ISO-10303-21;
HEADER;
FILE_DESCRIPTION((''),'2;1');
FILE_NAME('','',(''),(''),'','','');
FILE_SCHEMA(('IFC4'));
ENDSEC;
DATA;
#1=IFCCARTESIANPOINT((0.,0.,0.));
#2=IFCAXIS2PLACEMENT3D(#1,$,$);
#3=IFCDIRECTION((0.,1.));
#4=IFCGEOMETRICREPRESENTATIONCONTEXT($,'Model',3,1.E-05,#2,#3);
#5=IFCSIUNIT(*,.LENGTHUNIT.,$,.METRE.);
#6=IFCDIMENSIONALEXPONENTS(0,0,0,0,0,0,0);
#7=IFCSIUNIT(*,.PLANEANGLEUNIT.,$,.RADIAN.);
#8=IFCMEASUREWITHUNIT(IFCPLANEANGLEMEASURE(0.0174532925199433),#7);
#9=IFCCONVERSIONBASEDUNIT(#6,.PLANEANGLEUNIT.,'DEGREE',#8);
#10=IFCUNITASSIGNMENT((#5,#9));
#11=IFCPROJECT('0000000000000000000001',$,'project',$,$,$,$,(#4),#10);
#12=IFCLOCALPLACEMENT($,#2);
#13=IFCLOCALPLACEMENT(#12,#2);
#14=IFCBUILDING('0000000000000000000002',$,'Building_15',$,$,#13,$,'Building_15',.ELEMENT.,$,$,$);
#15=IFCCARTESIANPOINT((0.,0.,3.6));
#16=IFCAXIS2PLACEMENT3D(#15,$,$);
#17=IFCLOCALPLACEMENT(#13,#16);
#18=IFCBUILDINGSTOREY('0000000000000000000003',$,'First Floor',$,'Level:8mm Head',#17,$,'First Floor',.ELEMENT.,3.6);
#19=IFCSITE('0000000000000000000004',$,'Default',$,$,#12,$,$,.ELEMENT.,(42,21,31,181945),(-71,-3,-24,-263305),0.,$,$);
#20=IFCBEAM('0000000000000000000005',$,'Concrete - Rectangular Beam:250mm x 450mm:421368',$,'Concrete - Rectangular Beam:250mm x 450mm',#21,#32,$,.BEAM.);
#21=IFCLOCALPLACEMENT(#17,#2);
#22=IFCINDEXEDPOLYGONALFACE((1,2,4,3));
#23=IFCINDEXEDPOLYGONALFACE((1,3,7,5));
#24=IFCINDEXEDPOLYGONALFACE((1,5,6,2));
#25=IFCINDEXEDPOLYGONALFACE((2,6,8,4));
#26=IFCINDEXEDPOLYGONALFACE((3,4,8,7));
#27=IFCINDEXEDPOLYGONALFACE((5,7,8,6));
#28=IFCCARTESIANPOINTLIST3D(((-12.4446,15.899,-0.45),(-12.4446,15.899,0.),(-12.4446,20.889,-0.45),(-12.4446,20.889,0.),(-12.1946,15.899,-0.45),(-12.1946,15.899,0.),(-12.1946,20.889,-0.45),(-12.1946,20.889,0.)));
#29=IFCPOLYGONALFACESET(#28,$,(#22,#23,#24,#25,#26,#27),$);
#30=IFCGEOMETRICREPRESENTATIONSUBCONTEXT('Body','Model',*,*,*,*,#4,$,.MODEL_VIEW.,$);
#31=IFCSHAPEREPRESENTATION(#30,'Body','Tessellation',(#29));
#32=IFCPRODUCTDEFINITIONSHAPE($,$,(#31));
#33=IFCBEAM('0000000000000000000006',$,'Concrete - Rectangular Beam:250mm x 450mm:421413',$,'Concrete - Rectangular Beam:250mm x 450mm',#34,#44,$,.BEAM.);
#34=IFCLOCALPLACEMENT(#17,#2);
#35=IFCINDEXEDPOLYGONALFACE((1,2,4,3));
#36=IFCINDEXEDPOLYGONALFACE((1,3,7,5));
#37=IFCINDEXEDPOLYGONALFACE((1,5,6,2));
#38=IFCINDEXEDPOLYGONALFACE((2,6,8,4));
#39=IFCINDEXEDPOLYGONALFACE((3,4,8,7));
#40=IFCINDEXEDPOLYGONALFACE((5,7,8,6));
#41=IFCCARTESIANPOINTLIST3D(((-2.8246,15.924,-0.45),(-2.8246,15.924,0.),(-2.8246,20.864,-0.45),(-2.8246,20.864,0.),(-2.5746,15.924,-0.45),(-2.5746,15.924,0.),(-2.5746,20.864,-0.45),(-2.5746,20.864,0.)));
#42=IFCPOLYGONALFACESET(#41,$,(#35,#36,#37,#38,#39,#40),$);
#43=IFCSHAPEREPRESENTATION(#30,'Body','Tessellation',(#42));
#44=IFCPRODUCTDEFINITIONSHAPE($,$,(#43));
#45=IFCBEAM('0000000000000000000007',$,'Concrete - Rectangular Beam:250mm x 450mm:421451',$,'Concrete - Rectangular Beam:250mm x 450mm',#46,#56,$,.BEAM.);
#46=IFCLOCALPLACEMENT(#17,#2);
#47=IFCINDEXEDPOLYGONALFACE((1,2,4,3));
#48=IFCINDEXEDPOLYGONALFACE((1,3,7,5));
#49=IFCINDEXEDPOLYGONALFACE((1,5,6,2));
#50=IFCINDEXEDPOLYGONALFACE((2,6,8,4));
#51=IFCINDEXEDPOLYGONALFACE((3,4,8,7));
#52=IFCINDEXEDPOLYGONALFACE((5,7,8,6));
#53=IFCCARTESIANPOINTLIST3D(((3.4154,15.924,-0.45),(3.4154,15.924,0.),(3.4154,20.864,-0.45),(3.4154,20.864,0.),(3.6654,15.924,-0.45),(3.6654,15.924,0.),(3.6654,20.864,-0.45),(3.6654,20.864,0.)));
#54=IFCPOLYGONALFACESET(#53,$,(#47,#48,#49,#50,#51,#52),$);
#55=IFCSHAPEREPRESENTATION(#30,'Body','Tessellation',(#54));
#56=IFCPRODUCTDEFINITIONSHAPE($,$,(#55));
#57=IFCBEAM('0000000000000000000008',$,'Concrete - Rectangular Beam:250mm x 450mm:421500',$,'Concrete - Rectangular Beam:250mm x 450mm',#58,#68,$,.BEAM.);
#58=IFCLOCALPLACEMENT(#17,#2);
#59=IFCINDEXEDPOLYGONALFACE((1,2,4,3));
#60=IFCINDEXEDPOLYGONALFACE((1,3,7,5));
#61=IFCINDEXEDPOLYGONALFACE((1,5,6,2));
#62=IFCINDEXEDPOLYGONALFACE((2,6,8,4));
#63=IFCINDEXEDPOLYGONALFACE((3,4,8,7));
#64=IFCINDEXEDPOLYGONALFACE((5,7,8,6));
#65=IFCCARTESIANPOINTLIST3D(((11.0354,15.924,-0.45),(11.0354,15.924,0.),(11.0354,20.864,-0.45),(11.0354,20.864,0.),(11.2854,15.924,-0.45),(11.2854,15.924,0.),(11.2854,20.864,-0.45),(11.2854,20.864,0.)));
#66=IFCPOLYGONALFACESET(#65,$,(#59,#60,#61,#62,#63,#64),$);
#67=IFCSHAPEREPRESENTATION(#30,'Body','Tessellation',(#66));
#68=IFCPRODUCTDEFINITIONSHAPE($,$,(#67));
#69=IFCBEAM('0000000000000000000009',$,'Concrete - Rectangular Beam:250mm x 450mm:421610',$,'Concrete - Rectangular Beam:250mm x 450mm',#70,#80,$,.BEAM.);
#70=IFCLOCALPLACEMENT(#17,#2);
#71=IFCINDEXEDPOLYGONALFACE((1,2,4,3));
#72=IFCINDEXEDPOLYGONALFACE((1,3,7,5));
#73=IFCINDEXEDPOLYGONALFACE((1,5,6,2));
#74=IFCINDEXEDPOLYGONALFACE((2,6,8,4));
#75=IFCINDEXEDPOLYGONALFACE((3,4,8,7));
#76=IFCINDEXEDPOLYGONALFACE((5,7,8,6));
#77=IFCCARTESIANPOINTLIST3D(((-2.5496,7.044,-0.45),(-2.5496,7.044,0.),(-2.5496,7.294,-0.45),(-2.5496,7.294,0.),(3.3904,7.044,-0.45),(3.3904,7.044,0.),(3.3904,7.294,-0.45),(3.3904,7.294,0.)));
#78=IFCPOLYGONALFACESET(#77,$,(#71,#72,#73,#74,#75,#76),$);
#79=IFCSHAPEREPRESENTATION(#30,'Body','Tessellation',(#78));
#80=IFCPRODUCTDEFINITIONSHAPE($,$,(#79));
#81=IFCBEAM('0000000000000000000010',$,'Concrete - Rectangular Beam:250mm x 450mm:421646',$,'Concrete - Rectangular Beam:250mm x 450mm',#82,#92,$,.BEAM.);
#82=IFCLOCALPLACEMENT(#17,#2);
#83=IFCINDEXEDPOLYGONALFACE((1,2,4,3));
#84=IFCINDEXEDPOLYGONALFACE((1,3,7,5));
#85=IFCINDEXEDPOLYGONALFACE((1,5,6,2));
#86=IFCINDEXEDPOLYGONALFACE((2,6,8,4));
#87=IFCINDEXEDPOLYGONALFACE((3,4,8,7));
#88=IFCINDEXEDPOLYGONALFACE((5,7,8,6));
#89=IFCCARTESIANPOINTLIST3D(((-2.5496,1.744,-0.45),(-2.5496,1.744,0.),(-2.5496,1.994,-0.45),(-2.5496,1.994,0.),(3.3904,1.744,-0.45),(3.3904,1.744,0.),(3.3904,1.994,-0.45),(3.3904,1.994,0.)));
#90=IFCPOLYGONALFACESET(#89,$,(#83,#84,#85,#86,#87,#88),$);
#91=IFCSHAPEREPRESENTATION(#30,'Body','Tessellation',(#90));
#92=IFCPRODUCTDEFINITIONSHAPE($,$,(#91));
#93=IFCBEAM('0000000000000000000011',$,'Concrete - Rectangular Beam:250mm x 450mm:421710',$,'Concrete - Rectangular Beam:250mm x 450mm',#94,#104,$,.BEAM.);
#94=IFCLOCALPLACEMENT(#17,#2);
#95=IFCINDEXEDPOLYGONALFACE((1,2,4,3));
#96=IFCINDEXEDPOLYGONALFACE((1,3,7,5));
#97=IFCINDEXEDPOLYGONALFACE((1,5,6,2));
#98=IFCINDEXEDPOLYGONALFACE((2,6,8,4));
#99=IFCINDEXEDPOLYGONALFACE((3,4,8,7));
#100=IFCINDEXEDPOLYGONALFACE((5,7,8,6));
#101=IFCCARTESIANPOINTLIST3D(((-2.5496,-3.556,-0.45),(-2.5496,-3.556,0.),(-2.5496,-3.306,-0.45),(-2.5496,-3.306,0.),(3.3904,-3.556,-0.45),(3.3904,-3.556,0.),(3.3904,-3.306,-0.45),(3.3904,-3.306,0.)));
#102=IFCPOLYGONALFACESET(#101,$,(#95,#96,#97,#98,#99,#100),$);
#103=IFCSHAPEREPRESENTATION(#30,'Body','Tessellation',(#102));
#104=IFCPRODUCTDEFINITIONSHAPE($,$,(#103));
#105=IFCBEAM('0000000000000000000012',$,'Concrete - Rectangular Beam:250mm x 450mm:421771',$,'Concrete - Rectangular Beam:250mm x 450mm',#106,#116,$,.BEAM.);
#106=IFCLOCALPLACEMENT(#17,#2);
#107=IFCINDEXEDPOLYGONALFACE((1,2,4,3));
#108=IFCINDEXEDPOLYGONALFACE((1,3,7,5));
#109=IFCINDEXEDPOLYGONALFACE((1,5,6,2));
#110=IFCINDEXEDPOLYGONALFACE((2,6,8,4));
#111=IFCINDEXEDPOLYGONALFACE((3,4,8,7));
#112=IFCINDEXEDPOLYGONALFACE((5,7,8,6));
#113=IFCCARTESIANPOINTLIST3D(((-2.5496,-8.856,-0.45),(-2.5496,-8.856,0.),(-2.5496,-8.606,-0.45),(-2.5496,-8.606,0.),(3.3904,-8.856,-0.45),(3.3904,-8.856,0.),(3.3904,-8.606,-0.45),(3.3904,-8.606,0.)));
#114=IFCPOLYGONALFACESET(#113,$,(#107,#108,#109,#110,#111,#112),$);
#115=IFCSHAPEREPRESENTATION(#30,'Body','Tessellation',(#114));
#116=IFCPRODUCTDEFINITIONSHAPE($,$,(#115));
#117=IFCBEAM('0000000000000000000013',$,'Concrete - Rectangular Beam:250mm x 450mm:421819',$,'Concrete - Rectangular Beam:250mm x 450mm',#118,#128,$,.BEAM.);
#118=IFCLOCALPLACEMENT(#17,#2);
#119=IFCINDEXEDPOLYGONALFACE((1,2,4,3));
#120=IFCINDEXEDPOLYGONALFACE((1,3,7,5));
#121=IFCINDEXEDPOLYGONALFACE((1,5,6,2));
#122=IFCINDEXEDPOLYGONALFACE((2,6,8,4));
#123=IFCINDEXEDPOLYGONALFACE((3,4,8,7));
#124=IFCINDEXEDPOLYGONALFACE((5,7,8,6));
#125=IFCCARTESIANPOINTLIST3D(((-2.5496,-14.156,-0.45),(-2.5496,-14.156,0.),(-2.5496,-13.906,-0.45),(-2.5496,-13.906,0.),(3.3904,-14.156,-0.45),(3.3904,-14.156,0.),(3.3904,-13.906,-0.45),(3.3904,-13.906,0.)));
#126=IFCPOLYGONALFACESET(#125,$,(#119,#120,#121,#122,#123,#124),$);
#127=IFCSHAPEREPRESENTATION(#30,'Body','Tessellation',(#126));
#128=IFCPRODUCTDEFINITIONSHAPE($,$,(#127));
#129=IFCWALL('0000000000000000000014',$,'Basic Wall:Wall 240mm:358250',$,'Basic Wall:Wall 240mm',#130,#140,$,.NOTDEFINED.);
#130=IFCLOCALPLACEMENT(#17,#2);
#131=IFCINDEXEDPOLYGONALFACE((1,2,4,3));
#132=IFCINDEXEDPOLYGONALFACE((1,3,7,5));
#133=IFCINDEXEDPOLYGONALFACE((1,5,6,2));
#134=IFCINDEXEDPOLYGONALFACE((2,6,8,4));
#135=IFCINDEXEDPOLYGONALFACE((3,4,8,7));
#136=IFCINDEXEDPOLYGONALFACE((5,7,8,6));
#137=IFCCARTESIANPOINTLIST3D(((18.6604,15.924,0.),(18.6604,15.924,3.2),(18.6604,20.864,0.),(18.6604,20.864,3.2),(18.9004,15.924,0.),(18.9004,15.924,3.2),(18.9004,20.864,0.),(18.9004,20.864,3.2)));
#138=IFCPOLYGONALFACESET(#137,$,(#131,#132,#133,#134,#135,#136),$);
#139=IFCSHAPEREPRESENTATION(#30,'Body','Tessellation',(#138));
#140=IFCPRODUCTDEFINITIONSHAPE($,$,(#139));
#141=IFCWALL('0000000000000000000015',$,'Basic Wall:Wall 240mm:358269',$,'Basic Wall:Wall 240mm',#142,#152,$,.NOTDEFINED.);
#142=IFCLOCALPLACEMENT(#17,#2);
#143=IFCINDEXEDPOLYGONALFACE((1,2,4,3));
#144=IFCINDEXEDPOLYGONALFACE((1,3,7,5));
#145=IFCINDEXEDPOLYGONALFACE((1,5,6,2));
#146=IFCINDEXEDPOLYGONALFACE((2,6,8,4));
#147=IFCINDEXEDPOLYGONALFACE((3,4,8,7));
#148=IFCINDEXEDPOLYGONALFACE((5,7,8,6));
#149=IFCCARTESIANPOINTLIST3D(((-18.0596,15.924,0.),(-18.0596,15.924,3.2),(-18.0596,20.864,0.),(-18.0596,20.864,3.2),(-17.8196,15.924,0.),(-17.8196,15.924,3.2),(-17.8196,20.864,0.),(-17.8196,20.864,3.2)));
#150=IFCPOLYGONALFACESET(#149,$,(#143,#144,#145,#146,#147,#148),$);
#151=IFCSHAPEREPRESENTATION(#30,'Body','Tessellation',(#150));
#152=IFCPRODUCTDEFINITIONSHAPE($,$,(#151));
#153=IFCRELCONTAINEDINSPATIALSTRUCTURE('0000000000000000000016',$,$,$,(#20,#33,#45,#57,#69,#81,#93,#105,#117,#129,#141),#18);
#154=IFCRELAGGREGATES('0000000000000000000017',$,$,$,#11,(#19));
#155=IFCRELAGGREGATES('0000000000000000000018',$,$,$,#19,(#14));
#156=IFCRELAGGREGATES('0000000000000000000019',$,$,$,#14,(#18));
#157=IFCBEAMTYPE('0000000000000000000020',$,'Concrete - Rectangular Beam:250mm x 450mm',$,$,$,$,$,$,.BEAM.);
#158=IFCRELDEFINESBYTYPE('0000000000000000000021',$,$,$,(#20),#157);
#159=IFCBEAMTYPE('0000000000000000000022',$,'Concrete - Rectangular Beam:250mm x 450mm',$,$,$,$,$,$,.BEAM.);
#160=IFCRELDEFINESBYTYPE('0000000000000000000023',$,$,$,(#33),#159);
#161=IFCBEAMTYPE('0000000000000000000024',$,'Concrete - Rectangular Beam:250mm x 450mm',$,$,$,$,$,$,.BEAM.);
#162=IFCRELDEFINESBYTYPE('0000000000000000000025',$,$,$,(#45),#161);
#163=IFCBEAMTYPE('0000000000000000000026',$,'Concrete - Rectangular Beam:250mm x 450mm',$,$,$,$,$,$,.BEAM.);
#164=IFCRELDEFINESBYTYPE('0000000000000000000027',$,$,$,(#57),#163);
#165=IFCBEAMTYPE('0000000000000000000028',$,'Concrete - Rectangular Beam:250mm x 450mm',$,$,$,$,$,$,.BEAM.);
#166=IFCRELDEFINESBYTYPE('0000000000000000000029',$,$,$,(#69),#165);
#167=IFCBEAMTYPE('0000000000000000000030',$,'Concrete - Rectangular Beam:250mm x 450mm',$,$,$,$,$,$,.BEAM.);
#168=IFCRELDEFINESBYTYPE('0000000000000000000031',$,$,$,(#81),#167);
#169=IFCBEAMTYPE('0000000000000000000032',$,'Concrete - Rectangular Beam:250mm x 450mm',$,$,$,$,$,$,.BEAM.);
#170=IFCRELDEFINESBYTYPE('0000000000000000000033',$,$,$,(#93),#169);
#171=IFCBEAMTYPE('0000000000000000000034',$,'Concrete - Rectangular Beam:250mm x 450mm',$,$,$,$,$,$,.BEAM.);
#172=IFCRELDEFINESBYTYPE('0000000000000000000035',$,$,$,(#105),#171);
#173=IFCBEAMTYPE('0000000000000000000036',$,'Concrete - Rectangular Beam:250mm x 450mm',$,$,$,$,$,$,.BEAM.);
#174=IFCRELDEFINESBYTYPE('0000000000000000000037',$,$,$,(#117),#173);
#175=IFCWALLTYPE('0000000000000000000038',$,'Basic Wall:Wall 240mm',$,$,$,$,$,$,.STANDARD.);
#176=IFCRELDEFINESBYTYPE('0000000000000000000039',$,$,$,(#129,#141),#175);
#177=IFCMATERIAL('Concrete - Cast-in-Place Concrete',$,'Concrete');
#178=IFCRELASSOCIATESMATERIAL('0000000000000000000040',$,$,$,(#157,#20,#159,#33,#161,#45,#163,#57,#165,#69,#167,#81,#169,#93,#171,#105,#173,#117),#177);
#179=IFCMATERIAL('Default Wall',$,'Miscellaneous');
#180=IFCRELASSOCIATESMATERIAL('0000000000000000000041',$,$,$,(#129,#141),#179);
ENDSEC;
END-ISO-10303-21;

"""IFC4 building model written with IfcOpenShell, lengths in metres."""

from ifc_helpers import new_model, entity, si_unit, converted_unit, direction, frame, origin, place, context, subcontext, project, spatial, indexed_curve, outline, extrude, source, transform, mapped, material, type_object, type_shapes, element, save


model = new_model("IFC4")

# Units and contexts
model_context = context("Model", 3, precision=1e-05, world=origin(), true_north=direction((0.0, 1.0)))
body_context = subcontext(model_context, "Body", "Model", "MODEL_VIEW")
ifc_project = project(units=[si_unit("LENGTHUNIT", "METRE"), converted_unit("PLANEANGLEUNIT", "DEGREE", entity("IfcPlaneAngleMeasure", 0.0174532925199433), si_unit("PLANEANGLEUNIT", "RADIAN"), dimensions=[0, 0, 0, 0, 0, 0, 0])], contexts=[model_context])

# Site, building, storey
site_placement = place(None, origin())
site = spatial("IfcSite", under=ifc_project, at=site_placement, Name="Default", CompositionType="ELEMENT", RefLatitude=(42, 21, 31, 181945), RefLongitude=(-71, -3, -24, -263305), RefElevation=0.0)
building_placement = place(site_placement, origin())
building = spatial("IfcBuilding", under=site, at=building_placement, Name="Building_15", LongName="Building_15", CompositionType="ELEMENT")
storey_placement = place(building_placement, frame((0.0, 0.0, 3.6)))
storey = spatial("IfcBuildingStorey", under=building, at=storey_placement, Name="First Floor", ObjectType="Level:8mm Head", LongName="First Floor", CompositionType="ELEMENT", Elevation=3.6)

# Beams
ifc_material_1 = material(Name="Concrete - Cast-in-Place Concrete", Category="Concrete")
beam_type_1 = type_object("IfcBeamType", Name="Concrete - Rectangular Beam:250mm x 450mm", PredefinedType="BEAM", material=ifc_material_1)
shared_shape_1 = source(origin(), body_context, "Body", "SweptSolid", [
    extrude(outline(indexed_curve([(-0.125, -0.225), (0.125, -0.225), (0.125, 0.225), (-0.125, 0.225), (-0.125, -0.225)], self_intersect=False)), frame((-12.3196, 20.889, 3.375), z_axis=(0.0, -1.0, 0.0), x_axis=(-1.0, 0.0, 0.0)), (0.0, 0.0, 1.0), 4.99),
])
type_shapes(beam_type_1, [shared_shape_1])
beam_1_placement = place(storey_placement, frame((0.0, 0.0, -3.6)))
element("IfcBeam", 1, at=beam_1_placement, inside=storey, type_object=beam_type_1, material=ifc_material_1, Name="Concrete - Rectangular Beam:250mm x 450mm:421368", ObjectType="Concrete - Rectangular Beam:250mm x 450mm", PredefinedType="BEAM", context=body_context, shape_type="MappedRepresentation", body=[
    mapped(shared_shape_1, transform((0.0, 0.0, 0.0), scale=1.0)),
])
beam_type_2 = type_object("IfcBeamType", Name="Concrete - Rectangular Beam:250mm x 450mm", PredefinedType="BEAM", material=ifc_material_1)
shared_shape_2 = source(origin(), body_context, "Body", "SweptSolid", [
    extrude(outline(indexed_curve([(-0.125, -0.225), (0.125, -0.225), (0.125, 0.225), (-0.125, 0.225), (-0.125, -0.225)], self_intersect=False)), frame((-2.6996, 20.864, 3.375), z_axis=(0.0, -1.0, 0.0), x_axis=(-1.0, 0.0, 0.0)), (0.0, 0.0, 1.0), 4.94),
])
type_shapes(beam_type_2, [shared_shape_2])
beam_2_placement = place(storey_placement, frame((0.0, 0.0, -3.6)))
element("IfcBeam", 2, at=beam_2_placement, inside=storey, type_object=beam_type_2, material=ifc_material_1, Name="Concrete - Rectangular Beam:250mm x 450mm:421413", ObjectType="Concrete - Rectangular Beam:250mm x 450mm", PredefinedType="BEAM", context=body_context, shape_type="MappedRepresentation", body=[
    mapped(shared_shape_2, transform((0.0, 0.0, 0.0), scale=1.0)),
])
beam_type_3 = type_object("IfcBeamType", Name="Concrete - Rectangular Beam:250mm x 450mm", PredefinedType="BEAM", material=ifc_material_1)
shared_shape_3 = source(origin(), body_context, "Body", "SweptSolid", [
    extrude(outline(indexed_curve([(-0.125, -0.225), (0.125, -0.225), (0.125, 0.225), (-0.125, 0.225), (-0.125, -0.225)], self_intersect=False)), frame((3.5404, 20.864, 3.375), z_axis=(0.0, -1.0, 0.0), x_axis=(-1.0, 0.0, 0.0)), (0.0, 0.0, 1.0), 4.94),
])
type_shapes(beam_type_3, [shared_shape_3])
beam_3_placement = place(storey_placement, frame((0.0, 0.0, -3.6)))
element("IfcBeam", 3, at=beam_3_placement, inside=storey, type_object=beam_type_3, material=ifc_material_1, Name="Concrete - Rectangular Beam:250mm x 450mm:421451", ObjectType="Concrete - Rectangular Beam:250mm x 450mm", PredefinedType="BEAM", context=body_context, shape_type="MappedRepresentation", body=[
    mapped(shared_shape_3, transform((0.0, 0.0, 0.0), scale=1.0)),
])
beam_type_4 = type_object("IfcBeamType", Name="Concrete - Rectangular Beam:250mm x 450mm", PredefinedType="BEAM", material=ifc_material_1)
shared_shape_4 = source(origin(), body_context, "Body", "SweptSolid", [
    extrude(outline(indexed_curve([(-0.125, -0.225), (0.125, -0.225), (0.125, 0.225), (-0.125, 0.225), (-0.125, -0.225)], self_intersect=False)), frame((11.1604, 20.864, 3.375), z_axis=(0.0, -1.0, 0.0), x_axis=(-1.0, 0.0, 0.0)), (0.0, 0.0, 1.0), 4.94),
])
type_shapes(beam_type_4, [shared_shape_4])
beam_4_placement = place(storey_placement, frame((0.0, 0.0, -3.6)))
element("IfcBeam", 4, at=beam_4_placement, inside=storey, type_object=beam_type_4, material=ifc_material_1, Name="Concrete - Rectangular Beam:250mm x 450mm:421500", ObjectType="Concrete - Rectangular Beam:250mm x 450mm", PredefinedType="BEAM", context=body_context, shape_type="MappedRepresentation", body=[
    mapped(shared_shape_4, transform((0.0, 0.0, 0.0), scale=1.0)),
])
beam_type_5 = type_object("IfcBeamType", Name="Concrete - Rectangular Beam:250mm x 450mm", PredefinedType="BEAM", material=ifc_material_1)
shared_shape_5 = source(origin(), body_context, "Body", "SweptSolid", [
    extrude(outline(indexed_curve([(-0.225, -0.125), (0.225, -0.125), (0.225, 0.125), (-0.225, 0.125), (-0.225, -0.125)], self_intersect=False)), frame((-2.5496, 7.169, 3.375), z_axis=(1.0, 0.0, 0.0), x_axis=(0.0, 0.0, -1.0)), (0.0, 0.0, 1.0), 5.94),
])
type_shapes(beam_type_5, [shared_shape_5])
beam_5_placement = place(storey_placement, frame((0.0, 0.0, -3.6)))
element("IfcBeam", 5, at=beam_5_placement, inside=storey, type_object=beam_type_5, material=ifc_material_1, Name="Concrete - Rectangular Beam:250mm x 450mm:421610", ObjectType="Concrete - Rectangular Beam:250mm x 450mm", PredefinedType="BEAM", context=body_context, shape_type="MappedRepresentation", body=[
    mapped(shared_shape_5, transform((0.0, 0.0, 0.0), scale=1.0)),
])
beam_type_6 = type_object("IfcBeamType", Name="Concrete - Rectangular Beam:250mm x 450mm", PredefinedType="BEAM", material=ifc_material_1)
shared_shape_6 = source(origin(), body_context, "Body", "SweptSolid", [
    extrude(outline(indexed_curve([(-0.225, -0.125), (0.225, -0.125), (0.225, 0.125), (-0.225, 0.125), (-0.225, -0.125)], self_intersect=False)), frame((-2.5496, 1.869, 3.375), z_axis=(1.0, 0.0, 0.0), x_axis=(0.0, 0.0, -1.0)), (0.0, 0.0, 1.0), 5.94),
])
type_shapes(beam_type_6, [shared_shape_6])
beam_6_placement = place(storey_placement, frame((0.0, 0.0, -3.6)))
element("IfcBeam", 6, at=beam_6_placement, inside=storey, type_object=beam_type_6, material=ifc_material_1, Name="Concrete - Rectangular Beam:250mm x 450mm:421646", ObjectType="Concrete - Rectangular Beam:250mm x 450mm", PredefinedType="BEAM", context=body_context, shape_type="MappedRepresentation", body=[
    mapped(shared_shape_6, transform((0.0, 0.0, 0.0), scale=1.0)),
])
beam_type_7 = type_object("IfcBeamType", Name="Concrete - Rectangular Beam:250mm x 450mm", PredefinedType="BEAM", material=ifc_material_1)
shared_shape_7 = source(origin(), body_context, "Body", "SweptSolid", [
    extrude(outline(indexed_curve([(-0.225, -0.125), (0.225, -0.125), (0.225, 0.125), (-0.225, 0.125), (-0.225, -0.125)], self_intersect=False)), frame((-2.5496, -3.431, 3.375), z_axis=(1.0, 0.0, 0.0), x_axis=(0.0, 0.0, -1.0)), (0.0, 0.0, 1.0), 5.94),
])
type_shapes(beam_type_7, [shared_shape_7])
beam_7_placement = place(storey_placement, frame((0.0, 0.0, -3.6)))
element("IfcBeam", 7, at=beam_7_placement, inside=storey, type_object=beam_type_7, material=ifc_material_1, Name="Concrete - Rectangular Beam:250mm x 450mm:421710", ObjectType="Concrete - Rectangular Beam:250mm x 450mm", PredefinedType="BEAM", context=body_context, shape_type="MappedRepresentation", body=[
    mapped(shared_shape_7, transform((0.0, 0.0, 0.0), scale=1.0)),
])
beam_type_8 = type_object("IfcBeamType", Name="Concrete - Rectangular Beam:250mm x 450mm", PredefinedType="BEAM", material=ifc_material_1)
shared_shape_8 = source(origin(), body_context, "Body", "SweptSolid", [
    extrude(outline(indexed_curve([(-0.225, -0.125), (0.225, -0.125), (0.225, 0.125), (-0.225, 0.125), (-0.225, -0.125)], self_intersect=False)), frame((-2.5496, -8.731, 3.375), z_axis=(1.0, 0.0, 0.0), x_axis=(0.0, 0.0, -1.0)), (0.0, 0.0, 1.0), 5.94),
])
type_shapes(beam_type_8, [shared_shape_8])
beam_8_placement = place(storey_placement, frame((0.0, 0.0, -3.6)))
element("IfcBeam", 8, at=beam_8_placement, inside=storey, type_object=beam_type_8, material=ifc_material_1, Name="Concrete - Rectangular Beam:250mm x 450mm:421771", ObjectType="Concrete - Rectangular Beam:250mm x 450mm", PredefinedType="BEAM", context=body_context, shape_type="MappedRepresentation", body=[
    mapped(shared_shape_8, transform((0.0, 0.0, 0.0), scale=1.0)),
])
beam_type_9 = type_object("IfcBeamType", Name="Concrete - Rectangular Beam:250mm x 450mm", PredefinedType="BEAM", material=ifc_material_1)
shared_shape_9 = source(origin(), body_context, "Body", "SweptSolid", [
    extrude(outline(indexed_curve([(-0.225, -0.125), (0.225, -0.125), (0.225, 0.125), (-0.225, 0.125), (-0.225, -0.125)], self_intersect=False)), frame((-2.5496, -14.031, 3.375), z_axis=(1.0, 0.0, 0.0), x_axis=(0.0, 0.0, -1.0)), (0.0, 0.0, 1.0), 5.94),
])
type_shapes(beam_type_9, [shared_shape_9])
beam_9_placement = place(storey_placement, frame((0.0, 0.0, -3.6)))
element("IfcBeam", 9, at=beam_9_placement, inside=storey, type_object=beam_type_9, material=ifc_material_1, Name="Concrete - Rectangular Beam:250mm x 450mm:421819", ObjectType="Concrete - Rectangular Beam:250mm x 450mm", PredefinedType="BEAM", context=body_context, shape_type="MappedRepresentation", body=[
    mapped(shared_shape_9, transform((0.0, 0.0, 0.0), scale=1.0)),
])

# Walls
ifc_material_2 = material(Name="Default Wall", Category="Miscellaneous")
wall_type_1 = type_object("IfcWallType", Name="Basic Wall:Wall 240mm", PredefinedType="STANDARD")
wall_1_placement = place(storey_placement, frame((18.7804, 20.864, 0.0), z_axis=(0.0, 0.0, 1.0), x_axis=(0.0, -1.0, 0.0)))
element("IfcWall", 10, at=wall_1_placement, inside=storey, type_object=wall_type_1, material=ifc_material_2, Name="Basic Wall:Wall 240mm:358250", ObjectType="Basic Wall:Wall 240mm", PredefinedType="NOTDEFINED", context=body_context, shape_type="SweptSolid", body=[
    extrude(outline(indexed_curve([(4.94, 0.12), (0.0, 0.12), (0.0, -0.12), (4.94, -0.12), (4.94, 0.12)], self_intersect=False)), origin(), (0.0, 0.0, 1.0), 3.2),
])
wall_2_placement = place(storey_placement, frame((-17.9396, 15.924, 0.0), z_axis=(0.0, 0.0, 1.0), x_axis=(0.0, 1.0, 0.0)))
element("IfcWall", 11, at=wall_2_placement, inside=storey, type_object=wall_type_1, material=ifc_material_2, Name="Basic Wall:Wall 240mm:358269", ObjectType="Basic Wall:Wall 240mm", PredefinedType="NOTDEFINED", context=body_context, shape_type="SweptSolid", body=[
    extrude(outline(indexed_curve([(4.94, 0.12), (0.0, 0.12), (0.0, -0.12), (4.94, -0.12), (4.94, 0.12)], self_intersect=False)), origin(), (0.0, 0.0, 1.0), 3.2),
])

save(model, "model.ifc")
